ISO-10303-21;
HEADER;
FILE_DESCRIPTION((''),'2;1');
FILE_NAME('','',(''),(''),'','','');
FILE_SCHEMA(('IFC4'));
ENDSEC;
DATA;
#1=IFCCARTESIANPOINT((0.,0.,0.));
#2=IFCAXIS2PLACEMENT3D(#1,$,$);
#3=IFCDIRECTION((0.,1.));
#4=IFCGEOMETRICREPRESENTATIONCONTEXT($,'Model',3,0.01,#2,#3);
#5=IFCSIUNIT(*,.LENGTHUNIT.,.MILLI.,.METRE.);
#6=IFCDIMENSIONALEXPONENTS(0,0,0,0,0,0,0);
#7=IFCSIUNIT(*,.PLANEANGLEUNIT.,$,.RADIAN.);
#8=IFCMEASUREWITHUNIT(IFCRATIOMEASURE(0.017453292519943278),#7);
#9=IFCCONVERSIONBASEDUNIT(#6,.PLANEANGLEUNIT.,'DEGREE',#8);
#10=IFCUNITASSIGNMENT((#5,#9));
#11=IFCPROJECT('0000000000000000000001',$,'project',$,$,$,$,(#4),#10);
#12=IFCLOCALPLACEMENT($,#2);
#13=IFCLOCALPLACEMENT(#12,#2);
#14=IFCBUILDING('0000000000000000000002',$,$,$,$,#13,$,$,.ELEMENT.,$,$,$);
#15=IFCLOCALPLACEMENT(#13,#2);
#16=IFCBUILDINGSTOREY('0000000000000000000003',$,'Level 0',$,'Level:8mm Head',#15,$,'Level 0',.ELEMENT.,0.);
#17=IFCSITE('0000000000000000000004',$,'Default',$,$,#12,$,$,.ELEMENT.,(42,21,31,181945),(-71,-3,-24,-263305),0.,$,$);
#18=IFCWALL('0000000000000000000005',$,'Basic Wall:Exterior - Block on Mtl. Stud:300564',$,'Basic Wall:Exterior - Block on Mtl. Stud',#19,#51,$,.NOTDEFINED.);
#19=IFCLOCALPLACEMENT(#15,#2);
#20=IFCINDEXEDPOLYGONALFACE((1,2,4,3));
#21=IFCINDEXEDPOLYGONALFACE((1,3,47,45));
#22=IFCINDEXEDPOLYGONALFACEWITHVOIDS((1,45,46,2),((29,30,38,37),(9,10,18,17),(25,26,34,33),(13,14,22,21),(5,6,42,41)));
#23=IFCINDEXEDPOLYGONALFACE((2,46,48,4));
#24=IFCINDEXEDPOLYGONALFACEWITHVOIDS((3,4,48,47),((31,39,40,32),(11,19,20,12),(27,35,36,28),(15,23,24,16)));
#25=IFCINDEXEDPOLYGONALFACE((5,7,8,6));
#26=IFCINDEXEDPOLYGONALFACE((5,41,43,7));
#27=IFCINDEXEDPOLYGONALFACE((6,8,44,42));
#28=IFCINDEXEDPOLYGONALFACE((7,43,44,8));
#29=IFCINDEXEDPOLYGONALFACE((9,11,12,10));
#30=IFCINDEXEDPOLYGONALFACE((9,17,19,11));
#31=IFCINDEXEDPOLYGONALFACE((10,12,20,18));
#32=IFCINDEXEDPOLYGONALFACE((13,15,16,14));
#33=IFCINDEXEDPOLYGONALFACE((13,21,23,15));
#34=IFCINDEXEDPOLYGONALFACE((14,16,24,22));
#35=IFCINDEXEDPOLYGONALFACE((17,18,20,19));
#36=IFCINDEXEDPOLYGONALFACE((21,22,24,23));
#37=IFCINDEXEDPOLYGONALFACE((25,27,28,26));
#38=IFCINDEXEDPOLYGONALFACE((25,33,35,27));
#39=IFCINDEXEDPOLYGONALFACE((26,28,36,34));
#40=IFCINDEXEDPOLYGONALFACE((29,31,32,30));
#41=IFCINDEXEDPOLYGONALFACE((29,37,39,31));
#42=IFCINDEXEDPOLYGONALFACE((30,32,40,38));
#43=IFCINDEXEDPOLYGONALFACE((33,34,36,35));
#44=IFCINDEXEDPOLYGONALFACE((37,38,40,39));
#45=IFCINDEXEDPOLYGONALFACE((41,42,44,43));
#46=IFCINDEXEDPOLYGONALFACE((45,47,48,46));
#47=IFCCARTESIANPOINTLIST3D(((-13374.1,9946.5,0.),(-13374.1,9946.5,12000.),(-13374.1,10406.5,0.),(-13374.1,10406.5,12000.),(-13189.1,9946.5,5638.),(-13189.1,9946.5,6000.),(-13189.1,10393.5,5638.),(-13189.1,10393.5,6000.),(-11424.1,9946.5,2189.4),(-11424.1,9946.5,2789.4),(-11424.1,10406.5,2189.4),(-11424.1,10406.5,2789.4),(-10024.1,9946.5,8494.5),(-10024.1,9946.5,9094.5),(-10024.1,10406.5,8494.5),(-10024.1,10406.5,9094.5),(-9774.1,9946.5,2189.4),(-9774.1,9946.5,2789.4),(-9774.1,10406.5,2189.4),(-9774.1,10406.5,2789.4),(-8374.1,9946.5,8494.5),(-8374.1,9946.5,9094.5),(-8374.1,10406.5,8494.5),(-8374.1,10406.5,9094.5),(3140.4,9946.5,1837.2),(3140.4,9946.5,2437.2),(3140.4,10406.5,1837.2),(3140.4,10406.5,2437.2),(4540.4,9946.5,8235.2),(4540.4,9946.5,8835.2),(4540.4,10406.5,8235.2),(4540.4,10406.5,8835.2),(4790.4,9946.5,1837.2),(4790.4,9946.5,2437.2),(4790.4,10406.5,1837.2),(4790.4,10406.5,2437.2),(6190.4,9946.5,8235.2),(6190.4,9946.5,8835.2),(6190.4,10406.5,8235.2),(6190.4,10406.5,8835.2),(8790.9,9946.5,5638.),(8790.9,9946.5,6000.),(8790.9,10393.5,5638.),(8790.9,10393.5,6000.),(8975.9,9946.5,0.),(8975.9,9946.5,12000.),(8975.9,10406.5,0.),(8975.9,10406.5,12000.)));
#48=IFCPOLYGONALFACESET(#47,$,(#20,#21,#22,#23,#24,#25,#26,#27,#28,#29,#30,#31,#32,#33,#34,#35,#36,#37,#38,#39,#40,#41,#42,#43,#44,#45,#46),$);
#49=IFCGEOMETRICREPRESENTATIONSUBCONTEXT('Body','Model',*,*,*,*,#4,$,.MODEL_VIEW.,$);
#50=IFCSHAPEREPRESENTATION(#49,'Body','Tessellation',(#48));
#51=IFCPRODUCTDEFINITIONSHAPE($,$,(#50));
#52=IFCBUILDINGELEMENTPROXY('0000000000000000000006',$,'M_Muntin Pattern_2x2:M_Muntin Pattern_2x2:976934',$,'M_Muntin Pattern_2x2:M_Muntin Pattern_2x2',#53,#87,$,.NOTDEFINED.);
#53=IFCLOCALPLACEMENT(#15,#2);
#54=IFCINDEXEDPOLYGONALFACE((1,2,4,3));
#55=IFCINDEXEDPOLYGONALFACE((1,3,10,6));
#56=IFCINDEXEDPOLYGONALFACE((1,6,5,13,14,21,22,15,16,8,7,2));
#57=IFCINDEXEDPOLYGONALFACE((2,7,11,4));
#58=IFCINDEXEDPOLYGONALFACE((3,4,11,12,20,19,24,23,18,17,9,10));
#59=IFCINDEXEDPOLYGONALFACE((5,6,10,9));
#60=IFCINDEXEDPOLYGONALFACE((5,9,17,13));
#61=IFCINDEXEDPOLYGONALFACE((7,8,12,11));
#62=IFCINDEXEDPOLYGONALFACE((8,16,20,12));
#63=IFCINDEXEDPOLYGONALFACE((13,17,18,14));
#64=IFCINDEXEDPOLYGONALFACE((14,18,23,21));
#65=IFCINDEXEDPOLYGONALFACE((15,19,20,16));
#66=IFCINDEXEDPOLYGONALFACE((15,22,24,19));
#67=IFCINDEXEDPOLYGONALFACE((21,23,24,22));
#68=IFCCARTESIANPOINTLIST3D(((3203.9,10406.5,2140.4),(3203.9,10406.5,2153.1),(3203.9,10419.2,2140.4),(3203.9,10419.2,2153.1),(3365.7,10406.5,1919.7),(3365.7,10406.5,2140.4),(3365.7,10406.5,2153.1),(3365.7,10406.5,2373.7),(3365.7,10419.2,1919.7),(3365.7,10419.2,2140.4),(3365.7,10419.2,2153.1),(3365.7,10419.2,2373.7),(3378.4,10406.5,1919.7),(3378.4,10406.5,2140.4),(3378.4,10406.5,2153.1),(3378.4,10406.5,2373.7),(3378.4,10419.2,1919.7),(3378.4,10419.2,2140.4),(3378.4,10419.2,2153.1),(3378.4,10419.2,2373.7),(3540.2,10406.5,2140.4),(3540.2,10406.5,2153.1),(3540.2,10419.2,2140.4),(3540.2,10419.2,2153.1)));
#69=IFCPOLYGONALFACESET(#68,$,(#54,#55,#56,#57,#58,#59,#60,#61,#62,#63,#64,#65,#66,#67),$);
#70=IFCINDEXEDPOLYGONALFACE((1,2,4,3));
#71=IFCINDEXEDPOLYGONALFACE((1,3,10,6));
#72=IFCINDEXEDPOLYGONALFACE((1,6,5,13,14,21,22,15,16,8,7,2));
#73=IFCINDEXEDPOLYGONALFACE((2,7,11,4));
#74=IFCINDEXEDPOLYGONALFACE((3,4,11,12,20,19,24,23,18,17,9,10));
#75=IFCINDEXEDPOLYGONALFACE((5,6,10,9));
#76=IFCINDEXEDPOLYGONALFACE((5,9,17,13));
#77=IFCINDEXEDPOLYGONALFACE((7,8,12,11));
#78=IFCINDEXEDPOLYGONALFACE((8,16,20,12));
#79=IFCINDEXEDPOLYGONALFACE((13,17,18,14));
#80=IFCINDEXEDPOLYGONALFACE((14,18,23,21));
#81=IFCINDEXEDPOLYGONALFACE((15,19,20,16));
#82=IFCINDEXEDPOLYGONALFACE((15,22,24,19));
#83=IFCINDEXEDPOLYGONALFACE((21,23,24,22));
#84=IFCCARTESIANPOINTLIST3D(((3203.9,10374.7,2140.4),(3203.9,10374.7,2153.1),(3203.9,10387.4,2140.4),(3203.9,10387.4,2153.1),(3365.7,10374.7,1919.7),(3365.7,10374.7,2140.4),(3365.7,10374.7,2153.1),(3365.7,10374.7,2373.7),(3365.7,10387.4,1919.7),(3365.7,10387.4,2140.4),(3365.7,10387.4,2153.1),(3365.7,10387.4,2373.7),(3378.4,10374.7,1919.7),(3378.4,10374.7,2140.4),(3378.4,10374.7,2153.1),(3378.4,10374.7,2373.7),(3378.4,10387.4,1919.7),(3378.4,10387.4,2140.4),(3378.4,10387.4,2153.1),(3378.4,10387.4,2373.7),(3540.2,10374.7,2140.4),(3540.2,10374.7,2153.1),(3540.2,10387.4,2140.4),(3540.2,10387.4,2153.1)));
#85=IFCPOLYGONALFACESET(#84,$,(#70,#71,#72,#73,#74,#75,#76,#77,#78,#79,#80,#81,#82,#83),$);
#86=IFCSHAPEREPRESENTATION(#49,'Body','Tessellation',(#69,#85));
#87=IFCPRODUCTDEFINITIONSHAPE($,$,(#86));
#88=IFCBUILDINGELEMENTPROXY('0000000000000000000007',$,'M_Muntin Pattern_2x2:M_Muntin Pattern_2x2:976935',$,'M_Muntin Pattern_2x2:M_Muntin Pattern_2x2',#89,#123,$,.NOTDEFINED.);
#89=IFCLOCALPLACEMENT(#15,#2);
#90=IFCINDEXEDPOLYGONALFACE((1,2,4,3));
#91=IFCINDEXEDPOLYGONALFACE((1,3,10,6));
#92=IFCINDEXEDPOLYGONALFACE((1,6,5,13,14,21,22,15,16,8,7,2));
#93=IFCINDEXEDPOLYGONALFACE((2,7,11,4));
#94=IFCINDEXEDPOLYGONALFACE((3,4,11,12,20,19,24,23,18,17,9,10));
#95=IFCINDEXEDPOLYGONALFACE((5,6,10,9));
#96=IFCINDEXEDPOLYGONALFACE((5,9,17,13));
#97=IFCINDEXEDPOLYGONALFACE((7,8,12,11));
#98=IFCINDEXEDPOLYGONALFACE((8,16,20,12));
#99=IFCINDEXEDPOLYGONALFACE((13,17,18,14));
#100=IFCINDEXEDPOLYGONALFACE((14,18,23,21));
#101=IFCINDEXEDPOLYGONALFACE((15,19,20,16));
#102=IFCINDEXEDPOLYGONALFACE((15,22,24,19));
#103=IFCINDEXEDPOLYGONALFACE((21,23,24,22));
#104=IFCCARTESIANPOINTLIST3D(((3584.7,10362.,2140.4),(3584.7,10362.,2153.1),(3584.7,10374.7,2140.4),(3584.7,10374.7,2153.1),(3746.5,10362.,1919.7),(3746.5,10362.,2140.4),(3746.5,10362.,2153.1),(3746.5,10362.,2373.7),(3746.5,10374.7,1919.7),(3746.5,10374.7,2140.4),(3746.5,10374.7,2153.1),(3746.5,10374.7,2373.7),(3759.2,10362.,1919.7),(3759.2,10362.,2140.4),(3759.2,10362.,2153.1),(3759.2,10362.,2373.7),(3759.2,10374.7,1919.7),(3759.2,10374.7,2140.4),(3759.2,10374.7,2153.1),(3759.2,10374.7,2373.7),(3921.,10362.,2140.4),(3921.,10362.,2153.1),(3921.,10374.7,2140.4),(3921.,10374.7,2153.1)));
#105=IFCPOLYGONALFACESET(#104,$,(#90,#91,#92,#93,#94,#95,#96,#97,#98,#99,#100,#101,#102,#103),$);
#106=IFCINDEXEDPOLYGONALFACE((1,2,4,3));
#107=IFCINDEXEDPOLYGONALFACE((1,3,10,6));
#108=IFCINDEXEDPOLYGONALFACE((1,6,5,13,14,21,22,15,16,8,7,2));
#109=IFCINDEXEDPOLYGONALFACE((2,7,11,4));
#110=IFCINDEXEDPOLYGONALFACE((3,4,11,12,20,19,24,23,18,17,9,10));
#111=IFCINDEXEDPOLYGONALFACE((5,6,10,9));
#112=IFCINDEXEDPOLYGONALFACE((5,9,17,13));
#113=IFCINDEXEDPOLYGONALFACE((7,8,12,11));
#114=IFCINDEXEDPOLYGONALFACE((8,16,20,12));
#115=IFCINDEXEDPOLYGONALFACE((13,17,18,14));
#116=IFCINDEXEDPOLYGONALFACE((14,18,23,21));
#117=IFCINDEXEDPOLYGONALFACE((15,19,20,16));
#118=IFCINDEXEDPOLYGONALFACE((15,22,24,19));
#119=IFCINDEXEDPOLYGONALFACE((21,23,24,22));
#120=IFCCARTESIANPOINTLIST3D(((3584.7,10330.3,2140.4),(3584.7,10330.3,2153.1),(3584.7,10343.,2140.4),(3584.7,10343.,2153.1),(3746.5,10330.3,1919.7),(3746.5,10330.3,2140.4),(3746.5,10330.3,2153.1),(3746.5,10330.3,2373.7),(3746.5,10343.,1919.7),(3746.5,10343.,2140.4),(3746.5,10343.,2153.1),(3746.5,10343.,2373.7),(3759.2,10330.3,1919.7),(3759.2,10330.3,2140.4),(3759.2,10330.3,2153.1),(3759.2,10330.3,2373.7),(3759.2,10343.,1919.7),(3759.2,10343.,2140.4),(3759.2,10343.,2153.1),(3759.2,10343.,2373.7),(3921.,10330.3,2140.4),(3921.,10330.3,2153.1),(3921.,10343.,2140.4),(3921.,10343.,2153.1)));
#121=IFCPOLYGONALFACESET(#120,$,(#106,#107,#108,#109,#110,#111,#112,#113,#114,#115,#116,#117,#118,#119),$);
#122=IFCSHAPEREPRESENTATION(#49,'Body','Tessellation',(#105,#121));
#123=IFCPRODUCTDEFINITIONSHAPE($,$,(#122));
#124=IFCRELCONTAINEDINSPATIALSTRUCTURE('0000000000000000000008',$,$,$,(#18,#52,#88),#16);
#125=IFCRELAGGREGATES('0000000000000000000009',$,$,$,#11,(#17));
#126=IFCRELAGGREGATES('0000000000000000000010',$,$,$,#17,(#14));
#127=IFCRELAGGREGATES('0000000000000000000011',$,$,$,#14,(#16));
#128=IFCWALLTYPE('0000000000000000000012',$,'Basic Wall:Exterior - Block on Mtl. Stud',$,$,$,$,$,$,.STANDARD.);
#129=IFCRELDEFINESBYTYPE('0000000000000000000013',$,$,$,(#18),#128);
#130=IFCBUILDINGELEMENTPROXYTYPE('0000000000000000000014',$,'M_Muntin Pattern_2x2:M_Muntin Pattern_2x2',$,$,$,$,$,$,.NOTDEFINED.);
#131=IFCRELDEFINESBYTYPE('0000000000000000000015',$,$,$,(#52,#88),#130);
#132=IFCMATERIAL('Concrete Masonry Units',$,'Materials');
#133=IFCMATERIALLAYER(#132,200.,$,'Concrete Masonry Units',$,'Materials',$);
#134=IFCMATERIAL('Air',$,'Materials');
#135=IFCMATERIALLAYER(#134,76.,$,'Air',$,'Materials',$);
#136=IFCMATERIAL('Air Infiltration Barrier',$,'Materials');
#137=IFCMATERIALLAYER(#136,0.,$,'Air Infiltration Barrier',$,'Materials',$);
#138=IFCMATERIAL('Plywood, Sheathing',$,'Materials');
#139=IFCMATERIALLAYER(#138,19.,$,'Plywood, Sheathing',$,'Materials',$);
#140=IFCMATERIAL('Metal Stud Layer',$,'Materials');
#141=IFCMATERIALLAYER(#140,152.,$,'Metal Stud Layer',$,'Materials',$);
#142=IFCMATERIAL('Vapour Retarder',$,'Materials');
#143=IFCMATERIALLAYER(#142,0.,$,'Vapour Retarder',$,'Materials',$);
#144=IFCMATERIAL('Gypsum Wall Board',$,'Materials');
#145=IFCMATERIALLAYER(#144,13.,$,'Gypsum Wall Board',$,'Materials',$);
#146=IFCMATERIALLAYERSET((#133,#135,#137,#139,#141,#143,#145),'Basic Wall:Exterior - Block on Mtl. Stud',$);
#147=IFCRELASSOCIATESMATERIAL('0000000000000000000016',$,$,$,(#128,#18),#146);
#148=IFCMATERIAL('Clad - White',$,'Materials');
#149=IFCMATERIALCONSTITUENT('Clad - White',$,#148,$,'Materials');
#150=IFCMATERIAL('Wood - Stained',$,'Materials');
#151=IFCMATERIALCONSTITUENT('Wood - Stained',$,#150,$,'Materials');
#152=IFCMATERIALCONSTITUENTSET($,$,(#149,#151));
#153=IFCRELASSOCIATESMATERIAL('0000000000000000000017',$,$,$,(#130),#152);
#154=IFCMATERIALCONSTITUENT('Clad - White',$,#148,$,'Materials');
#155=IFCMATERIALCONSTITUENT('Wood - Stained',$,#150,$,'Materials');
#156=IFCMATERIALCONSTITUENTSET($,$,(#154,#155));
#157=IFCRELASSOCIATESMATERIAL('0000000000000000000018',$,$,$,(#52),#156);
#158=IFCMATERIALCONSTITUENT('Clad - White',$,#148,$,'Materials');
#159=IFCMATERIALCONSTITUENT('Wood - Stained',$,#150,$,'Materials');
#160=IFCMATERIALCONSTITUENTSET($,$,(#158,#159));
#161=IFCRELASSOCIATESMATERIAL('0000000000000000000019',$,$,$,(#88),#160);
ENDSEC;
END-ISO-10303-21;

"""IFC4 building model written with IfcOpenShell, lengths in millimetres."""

from ifc_helpers import new_model, entity, si_unit, converted_unit, direction, frame, frame_2d, origin, place, context, subcontext, project, spatial, polyline, rectangle, outline, extrude, source, transform, mapped, material, layer, layer_set, layer_usage, constituent, constituent_set, type_object, type_shapes, element, save


model = new_model("IFC4")

# Units and contexts
model_context = context("Model", 3, precision=0.01, world=origin(), true_north=direction((0.0, 1.0)))
body_context = subcontext(model_context, "Body", "Model", "MODEL_VIEW")
ifc_project = project(units=[si_unit("LENGTHUNIT", "METRE", prefix="MILLI"), converted_unit("PLANEANGLEUNIT", "DEGREE", entity("IfcRatioMeasure", 0.017453292519943278), si_unit("PLANEANGLEUNIT", "RADIAN"), dimensions=[0, 0, 0, 0, 0, 0, 0])], contexts=[model_context])

# Site, building, storey
site_placement = place(None, origin())
site = spatial("IfcSite", under=ifc_project, at=site_placement, Name="Default", CompositionType="ELEMENT", RefLatitude=(42, 21, 31, 181945), RefLongitude=(-71, -3, -24, -263305), RefElevation=0.0)
building_placement = place(site_placement, origin())
building = spatial("IfcBuilding", under=site, at=building_placement, CompositionType="ELEMENT")
storey_placement = place(building_placement, origin())
storey = spatial("IfcBuildingStorey", under=building, at=storey_placement, Name="Level 0", ObjectType="Level:8mm Head", LongName="Level 0", CompositionType="ELEMENT", Elevation=0.0)

# Wall, openings
ifc_material_1 = material(Name="Concrete Masonry Units", Category="Materials")
ifc_layer_1 = layer(ifc_material_1, 200.0, Name="Concrete Masonry Units", Category="Materials")
ifc_material_2 = material(Name="Air", Category="Materials")
ifc_layer_2 = layer(ifc_material_2, 76.0, Name="Air", Category="Materials")
ifc_material_3 = material(Name="Air Infiltration Barrier", Category="Materials")
ifc_layer_3 = layer(ifc_material_3, 0.0, Name="Air Infiltration Barrier", Category="Materials")
ifc_material_4 = material(Name="Plywood, Sheathing", Category="Materials")
ifc_layer_4 = layer(ifc_material_4, 19.0, Name="Plywood, Sheathing", Category="Materials")
ifc_material_5 = material(Name="Metal Stud Layer", Category="Materials")
ifc_layer_5 = layer(ifc_material_5, 152.0, Name="Metal Stud Layer", Category="Materials")
ifc_material_6 = material(Name="Vapour Retarder", Category="Materials")
ifc_layer_6 = layer(ifc_material_6, 0.0, Name="Vapour Retarder", Category="Materials")
ifc_material_7 = material(Name="Gypsum Wall Board", Category="Materials")
ifc_layer_7 = layer(ifc_material_7, 13.0, Name="Gypsum Wall Board", Category="Materials")
ifc_layer_set = layer_set([ifc_layer_1, ifc_layer_2, ifc_layer_3, ifc_layer_4, ifc_layer_5, ifc_layer_6, ifc_layer_7], Name="Basic Wall:Exterior - Block on Mtl. Stud")
ifc_layer_usage = layer_usage(ifc_layer_set, "AXIS2", "POSITIVE", -230.0)
wall_type = type_object("IfcWallType", Name="Basic Wall:Exterior - Block on Mtl. Stud", PredefinedType="STANDARD", material=ifc_layer_set)
wall_placement = place(storey_placement, frame((-13374.1, 10176.5, 0.0)))
wall = element("IfcWall", 1, at=wall_placement, inside=storey, type_object=wall_type, material=ifc_layer_usage, Name="Basic Wall:Exterior - Block on Mtl. Stud:300564", ObjectType="Basic Wall:Exterior - Block on Mtl. Stud", PredefinedType="NOTDEFINED", context=body_context, shape_type="SweptSolid", body=[
    extrude(rectangle(XDim=22350.0, YDim=460.0, at=frame_2d((11175.0, 0.0), x_axis=(-1.0, 0.0))), origin(), (0.0, 0.0, 1.0), 12000.0),
])
opening_1_placement = place(storey_placement, frame((-13374.1, 10176.5, 0.0)))
element("IfcOpeningElement", 2, at=opening_1_placement, cuts=wall, PredefinedType="OPENING", context=body_context, shape_type="SweptSolid", body=[
    extrude(rectangle(XDim=21980.0, YDim=447.0, at=frame_2d((0.0, -74.5), x_axis=(1.0, 0.0))), frame((11175.0, -81.0, 5638.0), z_axis=(0.0, 0.0, 1.0), x_axis=(-1.0, 0.0, 0.0)), (0.0, 0.0, 1.0), 362.0),
])
opening_2_placement = place(wall_placement, frame((16514.5, -230.0, 1837.2)))
element("IfcOpeningElement", 3, at=opening_2_placement, cuts=wall, PredefinedType="OPENING", context=body_context, shape_type="SweptSolid", body=[
    extrude(rectangle(XDim=600.0, YDim=1650.0, at=frame_2d((300.0, 825.0), x_axis=(-1.0, 0.0))), frame((0.0, 0.0, 0.0), z_axis=(0.0, 1.0, 0.0), x_axis=(0.0, 0.0, 1.0)), (0.0, 0.0, 1.0), 460.0),
])
opening_3_placement = place(wall_placement, frame((1950.0, -230.0, 2189.4)))
element("IfcOpeningElement", 4, at=opening_3_placement, cuts=wall, PredefinedType="OPENING", context=body_context, shape_type="SweptSolid", body=[
    extrude(rectangle(XDim=600.0, YDim=1650.0, at=frame_2d((300.0, 825.0), x_axis=(-1.0, 0.0))), frame((0.0, 0.0, 0.0), z_axis=(0.0, 1.0, 0.0), x_axis=(0.0, 0.0, 1.0)), (0.0, 0.0, 1.0), 460.0),
])
opening_4_placement = place(wall_placement, frame((17914.5, -230.0, 8235.2)))
element("IfcOpeningElement", 5, at=opening_4_placement, cuts=wall, PredefinedType="OPENING", context=body_context, shape_type="SweptSolid", body=[
    extrude(rectangle(XDim=600.0, YDim=1650.0, at=frame_2d((300.0, 825.0), x_axis=(-1.0, 0.0))), frame((0.0, 0.0, 0.0), z_axis=(0.0, 1.0, 0.0), x_axis=(0.0, 0.0, 1.0)), (0.0, 0.0, 1.0), 460.0),
])
opening_5_placement = place(wall_placement, frame((3350.0, -230.0, 8494.5)))
element("IfcOpeningElement", 6, at=opening_5_placement, cuts=wall, PredefinedType="OPENING", context=body_context, shape_type="SweptSolid", body=[
    extrude(rectangle(XDim=600.0, YDim=1650.0, at=frame_2d((300.0, 825.0), x_axis=(-1.0, 0.0))), frame((0.0, 0.0, 0.0), z_axis=(0.0, 1.0, 0.0), x_axis=(0.0, 0.0, 1.0)), (0.0, 0.0, 1.0), 460.0),
])

# Building element proxies
ifc_material_8 = material(Name="Clad - White", Category="Materials")
ifc_constituent_1 = constituent(ifc_material_8, Name="Clad - White", Category="Materials")
ifc_material_9 = material(Name="Wood - Stained", Category="Materials")
ifc_constituent_2 = constituent(ifc_material_9, Name="Wood - Stained", Category="Materials")
ifc_constituent_set_1 = constituent_set(constituents=[ifc_constituent_1, ifc_constituent_2])
ifc_constituent_3 = constituent(ifc_material_8, Name="Clad - White", Category="Materials")
ifc_constituent_4 = constituent(ifc_material_9, Name="Wood - Stained", Category="Materials")
ifc_constituent_set_2 = constituent_set(constituents=[ifc_constituent_3, ifc_constituent_4])
building_element_proxy_type_1 = type_object("IfcBuildingElementProxyType", Name="M_Muntin Pattern_2x2:M_Muntin Pattern_2x2", PredefinedType="NOTDEFINED", material=ifc_constituent_set_2)
shared_shape_1 = source(origin(), body_context, "Body", "SweptSolid", [
    extrude(outline(polyline([(6.4, -6.4), (227.0, -6.4), (227.0, 6.3), (6.4, 6.3), (6.4, 168.2), (-6.3, 168.2), (-6.3, 6.3), (-227.0, 6.3), (-227.0, -6.4), (-6.3, -6.4), (-6.3, -168.1), (6.4, -168.1), (6.4, -6.4)])), frame((0.0, 9.5, 227.0), z_axis=(0.0, 1.0, 0.0), x_axis=(0.0, 0.0, 1.0)), (0.0, 0.0, 1.0), 12.7),
    extrude(outline(polyline([(6.4, -6.4), (227.0, -6.4), (227.0, 6.3), (6.4, 6.3), (6.4, 168.2), (-6.3, 168.2), (-6.3, 6.3), (-227.0, 6.3), (-227.0, -6.4), (-6.3, -6.4), (-6.3, -168.1), (6.4, -168.1), (6.4, -6.4)])), frame((0.0, -22.2, 227.0), z_axis=(0.0, 1.0, 0.0), x_axis=(0.0, 0.0, 1.0)), (0.0, 0.0, 1.0), 12.7),
])
type_shapes(building_element_proxy_type_1, [shared_shape_1])
proxy_1_placement = place(storey_placement, frame((3372.1, 10396.9, 1919.7)))
element("IfcBuildingElementProxy", 7, at=proxy_1_placement, inside=storey, type_object=building_element_proxy_type_1, material=ifc_constituent_set_1, Name="M_Muntin Pattern_2x2:M_Muntin Pattern_2x2:976934", ObjectType="M_Muntin Pattern_2x2:M_Muntin Pattern_2x2", PredefinedType="NOTDEFINED", context=body_context, shape_type="MappedRepresentation", body=[
    mapped(shared_shape_1, transform((0.0, 0.0, 0.0), scale=1.0)),
])
ifc_constituent_5 = constituent(ifc_material_8, Name="Clad - White", Category="Materials")
ifc_constituent_6 = constituent(ifc_material_9, Name="Wood - Stained", Category="Materials")
ifc_constituent_set_3 = constituent_set(constituents=[ifc_constituent_5, ifc_constituent_6])
proxy_2_placement = place(storey_placement, frame((3752.8, 10352.5, 1919.7)))
element("IfcBuildingElementProxy", 8, at=proxy_2_placement, inside=storey, type_object=building_element_proxy_type_1, material=ifc_constituent_set_3, Name="M_Muntin Pattern_2x2:M_Muntin Pattern_2x2:976935", ObjectType="M_Muntin Pattern_2x2:M_Muntin Pattern_2x2", PredefinedType="NOTDEFINED", context=body_context, shape_type="MappedRepresentation", body=[
    mapped(shared_shape_1, transform((0.0, 0.0, 0.0), scale=1.0)),
])

save(model, "model.ifc")
